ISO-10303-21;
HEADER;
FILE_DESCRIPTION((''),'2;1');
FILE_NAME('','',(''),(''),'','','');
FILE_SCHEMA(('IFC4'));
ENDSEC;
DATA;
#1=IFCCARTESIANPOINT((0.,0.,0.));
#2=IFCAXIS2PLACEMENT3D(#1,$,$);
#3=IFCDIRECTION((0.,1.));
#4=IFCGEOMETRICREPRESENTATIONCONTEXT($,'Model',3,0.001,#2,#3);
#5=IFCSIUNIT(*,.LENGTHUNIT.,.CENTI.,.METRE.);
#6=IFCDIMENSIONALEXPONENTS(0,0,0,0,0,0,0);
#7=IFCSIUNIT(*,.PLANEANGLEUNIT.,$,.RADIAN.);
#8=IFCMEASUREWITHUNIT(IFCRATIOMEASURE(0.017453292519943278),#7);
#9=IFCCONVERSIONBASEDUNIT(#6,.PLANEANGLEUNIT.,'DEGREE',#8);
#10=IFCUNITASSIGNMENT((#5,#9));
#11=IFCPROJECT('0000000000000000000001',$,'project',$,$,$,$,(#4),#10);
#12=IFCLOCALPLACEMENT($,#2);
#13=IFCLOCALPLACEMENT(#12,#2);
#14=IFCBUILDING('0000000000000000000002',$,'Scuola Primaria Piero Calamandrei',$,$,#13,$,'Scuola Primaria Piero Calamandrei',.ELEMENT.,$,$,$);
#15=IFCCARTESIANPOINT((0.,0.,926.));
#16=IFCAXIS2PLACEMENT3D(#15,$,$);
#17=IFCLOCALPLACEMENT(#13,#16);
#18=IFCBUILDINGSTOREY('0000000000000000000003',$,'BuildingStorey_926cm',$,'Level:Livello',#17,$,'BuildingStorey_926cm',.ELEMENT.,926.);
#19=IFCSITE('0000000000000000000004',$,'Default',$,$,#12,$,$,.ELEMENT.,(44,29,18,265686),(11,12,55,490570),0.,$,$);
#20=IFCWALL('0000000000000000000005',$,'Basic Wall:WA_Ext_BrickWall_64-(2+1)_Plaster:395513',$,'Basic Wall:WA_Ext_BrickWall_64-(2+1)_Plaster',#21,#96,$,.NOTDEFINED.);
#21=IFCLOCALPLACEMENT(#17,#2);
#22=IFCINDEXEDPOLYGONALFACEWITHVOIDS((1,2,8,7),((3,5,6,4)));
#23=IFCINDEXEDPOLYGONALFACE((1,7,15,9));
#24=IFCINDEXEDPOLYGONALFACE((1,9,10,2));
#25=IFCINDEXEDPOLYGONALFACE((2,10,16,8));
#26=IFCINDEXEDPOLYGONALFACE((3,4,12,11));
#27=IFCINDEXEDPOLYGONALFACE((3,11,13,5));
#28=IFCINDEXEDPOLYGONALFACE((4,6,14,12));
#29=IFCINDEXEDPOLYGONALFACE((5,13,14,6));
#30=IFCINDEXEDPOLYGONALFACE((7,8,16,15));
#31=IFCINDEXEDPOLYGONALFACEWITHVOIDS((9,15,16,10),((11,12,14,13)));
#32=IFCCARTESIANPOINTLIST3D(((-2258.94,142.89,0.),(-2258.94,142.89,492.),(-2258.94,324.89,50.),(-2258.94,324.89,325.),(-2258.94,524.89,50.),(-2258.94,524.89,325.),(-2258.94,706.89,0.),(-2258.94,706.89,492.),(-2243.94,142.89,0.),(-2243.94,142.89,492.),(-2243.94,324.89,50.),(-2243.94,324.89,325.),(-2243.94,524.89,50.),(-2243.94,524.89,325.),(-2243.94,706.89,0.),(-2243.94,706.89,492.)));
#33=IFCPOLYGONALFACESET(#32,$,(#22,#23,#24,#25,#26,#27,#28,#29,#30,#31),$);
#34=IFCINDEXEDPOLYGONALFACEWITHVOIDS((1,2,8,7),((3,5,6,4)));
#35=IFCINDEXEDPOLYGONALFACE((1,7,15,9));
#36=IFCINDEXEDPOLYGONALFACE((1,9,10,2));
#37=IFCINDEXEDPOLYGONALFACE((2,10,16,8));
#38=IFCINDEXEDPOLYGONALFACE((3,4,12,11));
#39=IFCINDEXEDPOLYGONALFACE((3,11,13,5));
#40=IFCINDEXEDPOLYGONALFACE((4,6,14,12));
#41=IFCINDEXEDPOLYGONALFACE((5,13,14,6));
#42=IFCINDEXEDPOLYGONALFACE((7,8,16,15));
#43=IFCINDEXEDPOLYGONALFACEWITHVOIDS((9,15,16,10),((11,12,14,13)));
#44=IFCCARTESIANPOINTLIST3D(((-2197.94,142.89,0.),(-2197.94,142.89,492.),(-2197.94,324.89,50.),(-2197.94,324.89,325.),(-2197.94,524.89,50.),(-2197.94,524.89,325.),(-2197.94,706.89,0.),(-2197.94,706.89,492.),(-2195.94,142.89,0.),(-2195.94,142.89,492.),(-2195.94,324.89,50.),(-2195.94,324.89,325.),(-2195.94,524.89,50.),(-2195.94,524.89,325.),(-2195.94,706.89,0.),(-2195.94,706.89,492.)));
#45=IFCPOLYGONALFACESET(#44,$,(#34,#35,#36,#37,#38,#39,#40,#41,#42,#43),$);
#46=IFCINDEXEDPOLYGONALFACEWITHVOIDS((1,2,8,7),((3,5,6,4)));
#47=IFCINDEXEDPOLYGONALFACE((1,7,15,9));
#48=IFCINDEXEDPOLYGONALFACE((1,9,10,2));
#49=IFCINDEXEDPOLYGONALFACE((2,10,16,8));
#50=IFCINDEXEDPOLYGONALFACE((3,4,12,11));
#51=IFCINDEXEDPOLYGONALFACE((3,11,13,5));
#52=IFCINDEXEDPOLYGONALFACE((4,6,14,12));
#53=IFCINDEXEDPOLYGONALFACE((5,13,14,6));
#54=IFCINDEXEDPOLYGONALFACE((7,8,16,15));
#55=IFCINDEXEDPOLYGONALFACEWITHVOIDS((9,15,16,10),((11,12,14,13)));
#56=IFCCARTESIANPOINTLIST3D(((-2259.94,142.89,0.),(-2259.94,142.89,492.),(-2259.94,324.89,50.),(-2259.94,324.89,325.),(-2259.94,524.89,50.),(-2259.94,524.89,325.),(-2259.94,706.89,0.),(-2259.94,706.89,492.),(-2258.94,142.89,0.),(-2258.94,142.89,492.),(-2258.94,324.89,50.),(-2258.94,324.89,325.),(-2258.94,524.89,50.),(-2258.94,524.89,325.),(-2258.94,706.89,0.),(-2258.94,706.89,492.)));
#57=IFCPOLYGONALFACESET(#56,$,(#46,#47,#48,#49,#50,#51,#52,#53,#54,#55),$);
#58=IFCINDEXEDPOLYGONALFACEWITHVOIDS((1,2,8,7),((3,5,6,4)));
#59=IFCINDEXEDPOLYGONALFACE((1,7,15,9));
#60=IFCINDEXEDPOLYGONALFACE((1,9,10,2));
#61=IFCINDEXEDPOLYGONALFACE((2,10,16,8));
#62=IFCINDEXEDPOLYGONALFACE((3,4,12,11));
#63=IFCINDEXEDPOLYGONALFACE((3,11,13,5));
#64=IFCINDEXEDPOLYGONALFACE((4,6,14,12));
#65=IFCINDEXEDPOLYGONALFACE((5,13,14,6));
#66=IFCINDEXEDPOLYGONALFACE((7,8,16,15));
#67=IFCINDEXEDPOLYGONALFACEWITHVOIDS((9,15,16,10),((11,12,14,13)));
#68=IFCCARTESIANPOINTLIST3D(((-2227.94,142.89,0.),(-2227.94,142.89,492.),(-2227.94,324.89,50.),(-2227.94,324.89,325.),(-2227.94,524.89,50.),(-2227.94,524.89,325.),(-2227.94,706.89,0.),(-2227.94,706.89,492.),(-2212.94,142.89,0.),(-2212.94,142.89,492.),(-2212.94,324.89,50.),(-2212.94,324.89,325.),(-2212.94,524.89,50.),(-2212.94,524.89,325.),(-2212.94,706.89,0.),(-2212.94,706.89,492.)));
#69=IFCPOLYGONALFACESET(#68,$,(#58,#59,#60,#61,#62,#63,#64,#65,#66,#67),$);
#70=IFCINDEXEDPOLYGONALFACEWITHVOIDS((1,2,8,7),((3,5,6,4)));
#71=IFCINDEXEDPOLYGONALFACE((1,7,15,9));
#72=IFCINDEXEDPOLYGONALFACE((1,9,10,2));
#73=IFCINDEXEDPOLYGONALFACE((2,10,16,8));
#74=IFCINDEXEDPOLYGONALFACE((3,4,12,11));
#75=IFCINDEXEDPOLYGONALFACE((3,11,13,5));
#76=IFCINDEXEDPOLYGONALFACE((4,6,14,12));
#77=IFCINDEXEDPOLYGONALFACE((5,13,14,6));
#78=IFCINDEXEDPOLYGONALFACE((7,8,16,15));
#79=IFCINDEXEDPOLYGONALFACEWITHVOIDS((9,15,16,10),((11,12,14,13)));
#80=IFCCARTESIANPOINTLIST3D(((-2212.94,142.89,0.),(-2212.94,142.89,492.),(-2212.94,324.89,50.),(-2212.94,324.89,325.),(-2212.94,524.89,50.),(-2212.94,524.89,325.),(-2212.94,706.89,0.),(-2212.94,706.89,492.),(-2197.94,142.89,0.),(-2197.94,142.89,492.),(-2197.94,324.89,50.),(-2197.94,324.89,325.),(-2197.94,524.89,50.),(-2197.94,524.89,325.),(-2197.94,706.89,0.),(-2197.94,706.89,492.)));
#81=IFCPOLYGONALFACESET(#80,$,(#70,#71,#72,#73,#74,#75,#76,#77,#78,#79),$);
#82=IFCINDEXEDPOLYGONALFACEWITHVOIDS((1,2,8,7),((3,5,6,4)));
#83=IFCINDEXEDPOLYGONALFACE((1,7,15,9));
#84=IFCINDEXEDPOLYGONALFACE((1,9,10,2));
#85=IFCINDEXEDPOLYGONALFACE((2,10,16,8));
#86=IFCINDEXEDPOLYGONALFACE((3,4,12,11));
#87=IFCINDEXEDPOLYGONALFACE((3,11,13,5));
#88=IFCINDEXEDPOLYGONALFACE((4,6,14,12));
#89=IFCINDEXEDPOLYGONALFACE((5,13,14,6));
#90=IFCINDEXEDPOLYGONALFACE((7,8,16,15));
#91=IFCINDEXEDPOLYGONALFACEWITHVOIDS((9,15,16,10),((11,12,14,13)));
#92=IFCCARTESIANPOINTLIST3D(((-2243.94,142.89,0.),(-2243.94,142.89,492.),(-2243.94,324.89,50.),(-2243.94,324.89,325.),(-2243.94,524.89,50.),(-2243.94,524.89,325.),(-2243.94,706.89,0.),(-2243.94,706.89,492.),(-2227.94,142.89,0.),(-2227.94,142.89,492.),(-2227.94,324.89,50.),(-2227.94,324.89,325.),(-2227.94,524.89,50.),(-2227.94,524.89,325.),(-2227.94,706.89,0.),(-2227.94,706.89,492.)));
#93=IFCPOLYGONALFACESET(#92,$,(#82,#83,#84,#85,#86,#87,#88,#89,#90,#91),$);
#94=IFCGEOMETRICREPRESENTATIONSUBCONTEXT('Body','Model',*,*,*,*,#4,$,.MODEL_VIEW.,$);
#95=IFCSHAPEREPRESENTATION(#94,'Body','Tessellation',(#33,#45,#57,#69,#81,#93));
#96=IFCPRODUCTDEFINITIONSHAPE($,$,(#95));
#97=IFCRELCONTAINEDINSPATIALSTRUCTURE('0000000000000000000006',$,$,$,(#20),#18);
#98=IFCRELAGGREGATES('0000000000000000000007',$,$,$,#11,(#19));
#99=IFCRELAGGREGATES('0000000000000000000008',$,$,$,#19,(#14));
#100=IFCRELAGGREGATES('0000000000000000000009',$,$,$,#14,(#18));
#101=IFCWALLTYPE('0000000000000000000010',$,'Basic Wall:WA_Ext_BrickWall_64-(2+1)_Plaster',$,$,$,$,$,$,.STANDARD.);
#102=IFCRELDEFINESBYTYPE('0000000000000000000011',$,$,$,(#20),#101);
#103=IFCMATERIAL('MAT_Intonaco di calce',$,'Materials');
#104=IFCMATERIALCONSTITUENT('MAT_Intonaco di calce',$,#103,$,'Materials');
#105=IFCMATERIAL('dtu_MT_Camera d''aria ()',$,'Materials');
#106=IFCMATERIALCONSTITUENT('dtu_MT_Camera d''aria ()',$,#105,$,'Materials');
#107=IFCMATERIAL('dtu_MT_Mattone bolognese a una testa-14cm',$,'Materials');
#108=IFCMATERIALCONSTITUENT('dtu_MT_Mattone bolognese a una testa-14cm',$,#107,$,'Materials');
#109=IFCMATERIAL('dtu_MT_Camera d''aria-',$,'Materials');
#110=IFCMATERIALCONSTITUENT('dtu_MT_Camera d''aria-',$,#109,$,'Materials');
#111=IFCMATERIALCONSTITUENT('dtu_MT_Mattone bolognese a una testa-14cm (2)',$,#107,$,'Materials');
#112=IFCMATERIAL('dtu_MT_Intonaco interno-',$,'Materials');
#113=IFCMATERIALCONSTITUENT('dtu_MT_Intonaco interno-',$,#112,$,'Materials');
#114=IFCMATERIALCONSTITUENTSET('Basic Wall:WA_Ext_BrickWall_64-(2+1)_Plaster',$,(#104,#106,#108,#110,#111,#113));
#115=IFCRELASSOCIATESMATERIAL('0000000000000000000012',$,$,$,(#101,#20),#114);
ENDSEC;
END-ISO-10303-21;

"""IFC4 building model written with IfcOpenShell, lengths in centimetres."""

from ifc_helpers import new_model, entity, si_unit, converted_unit, direction, frame, origin, place, context, subcontext, project, spatial, indexed_curve, outline, extrude, material, constituent, constituent_set, type_object, element, save


model = new_model("IFC4")

# Units and contexts
model_context = context("Model", 3, precision=0.001, world=origin(), true_north=direction((0.0, 1.0)))
body_context = subcontext(model_context, "Body", "Model", "MODEL_VIEW")
ifc_project = project(units=[si_unit("LENGTHUNIT", "METRE", prefix="CENTI"), converted_unit("PLANEANGLEUNIT", "DEGREE", entity("IfcRatioMeasure", 0.017453292519943278), si_unit("PLANEANGLEUNIT", "RADIAN"), dimensions=[0, 0, 0, 0, 0, 0, 0])], contexts=[model_context])

# Site, building, storey
site_placement = place(None, origin())
site = spatial("IfcSite", under=ifc_project, at=site_placement, Name="Default", CompositionType="ELEMENT", RefLatitude=(44, 29, 18, 265686), RefLongitude=(11, 12, 55, 490570), RefElevation=0.0)
building_placement = place(site_placement, origin())
building = spatial("IfcBuilding", under=site, at=building_placement, Name="Scuola Primaria Piero Calamandrei", LongName="Scuola Primaria Piero Calamandrei", CompositionType="ELEMENT")
storey_placement = place(building_placement, frame((0.0, 0.0, 926.0)))
storey = spatial("IfcBuildingStorey", under=building, at=storey_placement, Name="BuildingStorey_926cm", ObjectType="Level:Livello", LongName="BuildingStorey_926cm", CompositionType="ELEMENT", Elevation=926.0)

# Wall, opening
ifc_material_1 = material(Name="MAT_Intonaco di calce", Category="Materials")
ifc_constituent_1 = constituent(ifc_material_1, Name="MAT_Intonaco di calce", Category="Materials")
ifc_material_2 = material(Name="dtu_MT_Camera d'aria ()", Category="Materials")
ifc_constituent_2 = constituent(ifc_material_2, Name="dtu_MT_Camera d'aria ()", Category="Materials")
ifc_material_3 = material(Name="dtu_MT_Mattone bolognese a una testa-14cm", Category="Materials")
ifc_constituent_3 = constituent(ifc_material_3, Name="dtu_MT_Mattone bolognese a una testa-14cm", Category="Materials")
ifc_material_4 = material(Name="dtu_MT_Camera d'aria-", Category="Materials")
ifc_constituent_4 = constituent(ifc_material_4, Name="dtu_MT_Camera d'aria-", Category="Materials")
ifc_constituent_5 = constituent(ifc_material_3, Name="dtu_MT_Mattone bolognese a una testa-14cm (2)", Category="Materials")
ifc_material_5 = material(Name="dtu_MT_Intonaco interno-", Category="Materials")
ifc_constituent_6 = constituent(ifc_material_5, Name="dtu_MT_Intonaco interno-", Category="Materials")
ifc_constituent_set_1 = constituent_set(constituents=[ifc_constituent_1, ifc_constituent_2, ifc_constituent_3, ifc_constituent_4, ifc_constituent_5, ifc_constituent_6], Name="Basic Wall:WA_Ext_BrickWall_64-(2+1)_Plaster")
wall_type_1 = type_object("IfcWallType", Name="Basic Wall:WA_Ext_BrickWall_64-(2+1)_Plaster", PredefinedType="STANDARD", material=ifc_constituent_set_1)
wall_1_placement = place(storey_placement, frame((-2227.94, 706.89, 0.0), z_axis=(0.0, 0.0, 1.0), x_axis=(0.0, -1.0, 0.0)))
wall_1 = element("IfcWall", 1, at=wall_1_placement, inside=storey, type_object=wall_type_1, material=ifc_constituent_set_1, Name="Basic Wall:WA_Ext_BrickWall_64-(2+1)_Plaster:395513", ObjectType="Basic Wall:WA_Ext_BrickWall_64-(2+1)_Plaster", PredefinedType="NOTDEFINED", context=body_context, shape_type="SweptSolid", body=[
    extrude(outline(indexed_curve([(-246.0, -282.0), (246.0, -282.0), (246.0, 282.0), (-246.0, 282.0), (-246.0, -282.0)], self_intersect=False), holes=[indexed_curve([(-196.0, -100.0), (-196.0, 100.0), (79.0, 100.0), (79.0, -100.0), (-196.0, -100.0)], self_intersect=False)]), frame((282.0, -31.0, 246.0), z_axis=(0.0, 1.0, 0.0), x_axis=(0.0, 0.0, 1.0)), (0.0, 0.0, 1.0), 15.0),
    extrude(outline(indexed_curve([(-246.0, -282.0), (246.0, -282.0), (246.0, 282.0), (-246.0, 282.0), (-246.0, -282.0)], self_intersect=False), holes=[indexed_curve([(-196.0, -100.0), (-196.0, 100.0), (79.0, 100.0), (79.0, -100.0), (-196.0, -100.0)], self_intersect=False)]), frame((282.0, 30.0, 246.0), z_axis=(0.0, 1.0, 0.0), x_axis=(0.0, 0.0, 1.0)), (0.0, 0.0, 1.0), 2.0),
    extrude(outline(indexed_curve([(-246.0, -282.0), (246.0, -282.0), (246.0, -273.5), (246.0, 273.5), (246.0, 282.0), (-246.0, 282.0), (-246.0, 273.5), (-246.0, -273.5), (-246.0, -282.0)], self_intersect=False), holes=[indexed_curve([(79.0, -100.0), (-196.0, -100.0), (-196.0, 100.0), (79.0, 100.0), (79.0, -100.0)], self_intersect=False)]), frame((282.0, -32.0, 246.0), z_axis=(0.0, 1.0, 0.0), x_axis=(0.0, 0.0, 1.0)), (0.0, 0.0, 1.0), 1.0),
    extrude(outline(indexed_curve([(-246.0, -282.0), (246.0, -282.0), (246.0, 282.0), (-246.0, 282.0), (-246.0, -282.0)], self_intersect=False), holes=[indexed_curve([(-196.0, -100.0), (-196.0, 100.0), (79.0, 100.0), (79.0, -100.0), (-196.0, -100.0)], self_intersect=False)]), frame((282.0, 0.0, 246.0), z_axis=(0.0, 1.0, 0.0), x_axis=(0.0, 0.0, 1.0)), (0.0, 0.0, 1.0), 15.0),
    extrude(outline(indexed_curve([(-246.0, -282.0), (246.0, -282.0), (246.0, 282.0), (-246.0, 282.0), (-246.0, -282.0)], self_intersect=False), holes=[indexed_curve([(-196.0, -100.0), (-196.0, 100.0), (79.0, 100.0), (79.0, -100.0), (-196.0, -100.0)], self_intersect=False)]), frame((282.0, 15.0, 246.0), z_axis=(0.0, 1.0, 0.0), x_axis=(0.0, 0.0, 1.0)), (0.0, 0.0, 1.0), 15.0),
    extrude(outline(indexed_curve([(-246.0, -282.0), (246.0, -282.0), (246.0, 282.0), (-246.0, 282.0), (-246.0, -282.0)], self_intersect=False), holes=[indexed_curve([(-196.0, -100.0), (-196.0, 100.0), (79.0, 100.0), (79.0, -100.0), (-196.0, -100.0)], self_intersect=False)]), frame((282.0, -16.0, 246.0), z_axis=(0.0, 1.0, 0.0), x_axis=(0.0, 0.0, 1.0)), (0.0, 0.0, 1.0), 16.0),
])
opening_1_placement = place(wall_1_placement, frame((182.0, -32.0, 50.0)))
element("IfcOpeningElement", 2, at=opening_1_placement, cuts=wall_1, PredefinedType="OPENING", context=body_context, shape_type="SweptSolid", body=[
    extrude(outline(indexed_curve([(275.0, 0.0), (275.0, 200.0), (0.0, 200.0), (0.0, 0.0), (275.0, 0.0)], self_intersect=False)), frame((0.0, 0.0, 0.0), z_axis=(0.0, 1.0, 0.0), x_axis=(0.0, 0.0, 1.0)), (0.0, 0.0, 1.0), 64.0),
])

save(model, "model.ifc")
